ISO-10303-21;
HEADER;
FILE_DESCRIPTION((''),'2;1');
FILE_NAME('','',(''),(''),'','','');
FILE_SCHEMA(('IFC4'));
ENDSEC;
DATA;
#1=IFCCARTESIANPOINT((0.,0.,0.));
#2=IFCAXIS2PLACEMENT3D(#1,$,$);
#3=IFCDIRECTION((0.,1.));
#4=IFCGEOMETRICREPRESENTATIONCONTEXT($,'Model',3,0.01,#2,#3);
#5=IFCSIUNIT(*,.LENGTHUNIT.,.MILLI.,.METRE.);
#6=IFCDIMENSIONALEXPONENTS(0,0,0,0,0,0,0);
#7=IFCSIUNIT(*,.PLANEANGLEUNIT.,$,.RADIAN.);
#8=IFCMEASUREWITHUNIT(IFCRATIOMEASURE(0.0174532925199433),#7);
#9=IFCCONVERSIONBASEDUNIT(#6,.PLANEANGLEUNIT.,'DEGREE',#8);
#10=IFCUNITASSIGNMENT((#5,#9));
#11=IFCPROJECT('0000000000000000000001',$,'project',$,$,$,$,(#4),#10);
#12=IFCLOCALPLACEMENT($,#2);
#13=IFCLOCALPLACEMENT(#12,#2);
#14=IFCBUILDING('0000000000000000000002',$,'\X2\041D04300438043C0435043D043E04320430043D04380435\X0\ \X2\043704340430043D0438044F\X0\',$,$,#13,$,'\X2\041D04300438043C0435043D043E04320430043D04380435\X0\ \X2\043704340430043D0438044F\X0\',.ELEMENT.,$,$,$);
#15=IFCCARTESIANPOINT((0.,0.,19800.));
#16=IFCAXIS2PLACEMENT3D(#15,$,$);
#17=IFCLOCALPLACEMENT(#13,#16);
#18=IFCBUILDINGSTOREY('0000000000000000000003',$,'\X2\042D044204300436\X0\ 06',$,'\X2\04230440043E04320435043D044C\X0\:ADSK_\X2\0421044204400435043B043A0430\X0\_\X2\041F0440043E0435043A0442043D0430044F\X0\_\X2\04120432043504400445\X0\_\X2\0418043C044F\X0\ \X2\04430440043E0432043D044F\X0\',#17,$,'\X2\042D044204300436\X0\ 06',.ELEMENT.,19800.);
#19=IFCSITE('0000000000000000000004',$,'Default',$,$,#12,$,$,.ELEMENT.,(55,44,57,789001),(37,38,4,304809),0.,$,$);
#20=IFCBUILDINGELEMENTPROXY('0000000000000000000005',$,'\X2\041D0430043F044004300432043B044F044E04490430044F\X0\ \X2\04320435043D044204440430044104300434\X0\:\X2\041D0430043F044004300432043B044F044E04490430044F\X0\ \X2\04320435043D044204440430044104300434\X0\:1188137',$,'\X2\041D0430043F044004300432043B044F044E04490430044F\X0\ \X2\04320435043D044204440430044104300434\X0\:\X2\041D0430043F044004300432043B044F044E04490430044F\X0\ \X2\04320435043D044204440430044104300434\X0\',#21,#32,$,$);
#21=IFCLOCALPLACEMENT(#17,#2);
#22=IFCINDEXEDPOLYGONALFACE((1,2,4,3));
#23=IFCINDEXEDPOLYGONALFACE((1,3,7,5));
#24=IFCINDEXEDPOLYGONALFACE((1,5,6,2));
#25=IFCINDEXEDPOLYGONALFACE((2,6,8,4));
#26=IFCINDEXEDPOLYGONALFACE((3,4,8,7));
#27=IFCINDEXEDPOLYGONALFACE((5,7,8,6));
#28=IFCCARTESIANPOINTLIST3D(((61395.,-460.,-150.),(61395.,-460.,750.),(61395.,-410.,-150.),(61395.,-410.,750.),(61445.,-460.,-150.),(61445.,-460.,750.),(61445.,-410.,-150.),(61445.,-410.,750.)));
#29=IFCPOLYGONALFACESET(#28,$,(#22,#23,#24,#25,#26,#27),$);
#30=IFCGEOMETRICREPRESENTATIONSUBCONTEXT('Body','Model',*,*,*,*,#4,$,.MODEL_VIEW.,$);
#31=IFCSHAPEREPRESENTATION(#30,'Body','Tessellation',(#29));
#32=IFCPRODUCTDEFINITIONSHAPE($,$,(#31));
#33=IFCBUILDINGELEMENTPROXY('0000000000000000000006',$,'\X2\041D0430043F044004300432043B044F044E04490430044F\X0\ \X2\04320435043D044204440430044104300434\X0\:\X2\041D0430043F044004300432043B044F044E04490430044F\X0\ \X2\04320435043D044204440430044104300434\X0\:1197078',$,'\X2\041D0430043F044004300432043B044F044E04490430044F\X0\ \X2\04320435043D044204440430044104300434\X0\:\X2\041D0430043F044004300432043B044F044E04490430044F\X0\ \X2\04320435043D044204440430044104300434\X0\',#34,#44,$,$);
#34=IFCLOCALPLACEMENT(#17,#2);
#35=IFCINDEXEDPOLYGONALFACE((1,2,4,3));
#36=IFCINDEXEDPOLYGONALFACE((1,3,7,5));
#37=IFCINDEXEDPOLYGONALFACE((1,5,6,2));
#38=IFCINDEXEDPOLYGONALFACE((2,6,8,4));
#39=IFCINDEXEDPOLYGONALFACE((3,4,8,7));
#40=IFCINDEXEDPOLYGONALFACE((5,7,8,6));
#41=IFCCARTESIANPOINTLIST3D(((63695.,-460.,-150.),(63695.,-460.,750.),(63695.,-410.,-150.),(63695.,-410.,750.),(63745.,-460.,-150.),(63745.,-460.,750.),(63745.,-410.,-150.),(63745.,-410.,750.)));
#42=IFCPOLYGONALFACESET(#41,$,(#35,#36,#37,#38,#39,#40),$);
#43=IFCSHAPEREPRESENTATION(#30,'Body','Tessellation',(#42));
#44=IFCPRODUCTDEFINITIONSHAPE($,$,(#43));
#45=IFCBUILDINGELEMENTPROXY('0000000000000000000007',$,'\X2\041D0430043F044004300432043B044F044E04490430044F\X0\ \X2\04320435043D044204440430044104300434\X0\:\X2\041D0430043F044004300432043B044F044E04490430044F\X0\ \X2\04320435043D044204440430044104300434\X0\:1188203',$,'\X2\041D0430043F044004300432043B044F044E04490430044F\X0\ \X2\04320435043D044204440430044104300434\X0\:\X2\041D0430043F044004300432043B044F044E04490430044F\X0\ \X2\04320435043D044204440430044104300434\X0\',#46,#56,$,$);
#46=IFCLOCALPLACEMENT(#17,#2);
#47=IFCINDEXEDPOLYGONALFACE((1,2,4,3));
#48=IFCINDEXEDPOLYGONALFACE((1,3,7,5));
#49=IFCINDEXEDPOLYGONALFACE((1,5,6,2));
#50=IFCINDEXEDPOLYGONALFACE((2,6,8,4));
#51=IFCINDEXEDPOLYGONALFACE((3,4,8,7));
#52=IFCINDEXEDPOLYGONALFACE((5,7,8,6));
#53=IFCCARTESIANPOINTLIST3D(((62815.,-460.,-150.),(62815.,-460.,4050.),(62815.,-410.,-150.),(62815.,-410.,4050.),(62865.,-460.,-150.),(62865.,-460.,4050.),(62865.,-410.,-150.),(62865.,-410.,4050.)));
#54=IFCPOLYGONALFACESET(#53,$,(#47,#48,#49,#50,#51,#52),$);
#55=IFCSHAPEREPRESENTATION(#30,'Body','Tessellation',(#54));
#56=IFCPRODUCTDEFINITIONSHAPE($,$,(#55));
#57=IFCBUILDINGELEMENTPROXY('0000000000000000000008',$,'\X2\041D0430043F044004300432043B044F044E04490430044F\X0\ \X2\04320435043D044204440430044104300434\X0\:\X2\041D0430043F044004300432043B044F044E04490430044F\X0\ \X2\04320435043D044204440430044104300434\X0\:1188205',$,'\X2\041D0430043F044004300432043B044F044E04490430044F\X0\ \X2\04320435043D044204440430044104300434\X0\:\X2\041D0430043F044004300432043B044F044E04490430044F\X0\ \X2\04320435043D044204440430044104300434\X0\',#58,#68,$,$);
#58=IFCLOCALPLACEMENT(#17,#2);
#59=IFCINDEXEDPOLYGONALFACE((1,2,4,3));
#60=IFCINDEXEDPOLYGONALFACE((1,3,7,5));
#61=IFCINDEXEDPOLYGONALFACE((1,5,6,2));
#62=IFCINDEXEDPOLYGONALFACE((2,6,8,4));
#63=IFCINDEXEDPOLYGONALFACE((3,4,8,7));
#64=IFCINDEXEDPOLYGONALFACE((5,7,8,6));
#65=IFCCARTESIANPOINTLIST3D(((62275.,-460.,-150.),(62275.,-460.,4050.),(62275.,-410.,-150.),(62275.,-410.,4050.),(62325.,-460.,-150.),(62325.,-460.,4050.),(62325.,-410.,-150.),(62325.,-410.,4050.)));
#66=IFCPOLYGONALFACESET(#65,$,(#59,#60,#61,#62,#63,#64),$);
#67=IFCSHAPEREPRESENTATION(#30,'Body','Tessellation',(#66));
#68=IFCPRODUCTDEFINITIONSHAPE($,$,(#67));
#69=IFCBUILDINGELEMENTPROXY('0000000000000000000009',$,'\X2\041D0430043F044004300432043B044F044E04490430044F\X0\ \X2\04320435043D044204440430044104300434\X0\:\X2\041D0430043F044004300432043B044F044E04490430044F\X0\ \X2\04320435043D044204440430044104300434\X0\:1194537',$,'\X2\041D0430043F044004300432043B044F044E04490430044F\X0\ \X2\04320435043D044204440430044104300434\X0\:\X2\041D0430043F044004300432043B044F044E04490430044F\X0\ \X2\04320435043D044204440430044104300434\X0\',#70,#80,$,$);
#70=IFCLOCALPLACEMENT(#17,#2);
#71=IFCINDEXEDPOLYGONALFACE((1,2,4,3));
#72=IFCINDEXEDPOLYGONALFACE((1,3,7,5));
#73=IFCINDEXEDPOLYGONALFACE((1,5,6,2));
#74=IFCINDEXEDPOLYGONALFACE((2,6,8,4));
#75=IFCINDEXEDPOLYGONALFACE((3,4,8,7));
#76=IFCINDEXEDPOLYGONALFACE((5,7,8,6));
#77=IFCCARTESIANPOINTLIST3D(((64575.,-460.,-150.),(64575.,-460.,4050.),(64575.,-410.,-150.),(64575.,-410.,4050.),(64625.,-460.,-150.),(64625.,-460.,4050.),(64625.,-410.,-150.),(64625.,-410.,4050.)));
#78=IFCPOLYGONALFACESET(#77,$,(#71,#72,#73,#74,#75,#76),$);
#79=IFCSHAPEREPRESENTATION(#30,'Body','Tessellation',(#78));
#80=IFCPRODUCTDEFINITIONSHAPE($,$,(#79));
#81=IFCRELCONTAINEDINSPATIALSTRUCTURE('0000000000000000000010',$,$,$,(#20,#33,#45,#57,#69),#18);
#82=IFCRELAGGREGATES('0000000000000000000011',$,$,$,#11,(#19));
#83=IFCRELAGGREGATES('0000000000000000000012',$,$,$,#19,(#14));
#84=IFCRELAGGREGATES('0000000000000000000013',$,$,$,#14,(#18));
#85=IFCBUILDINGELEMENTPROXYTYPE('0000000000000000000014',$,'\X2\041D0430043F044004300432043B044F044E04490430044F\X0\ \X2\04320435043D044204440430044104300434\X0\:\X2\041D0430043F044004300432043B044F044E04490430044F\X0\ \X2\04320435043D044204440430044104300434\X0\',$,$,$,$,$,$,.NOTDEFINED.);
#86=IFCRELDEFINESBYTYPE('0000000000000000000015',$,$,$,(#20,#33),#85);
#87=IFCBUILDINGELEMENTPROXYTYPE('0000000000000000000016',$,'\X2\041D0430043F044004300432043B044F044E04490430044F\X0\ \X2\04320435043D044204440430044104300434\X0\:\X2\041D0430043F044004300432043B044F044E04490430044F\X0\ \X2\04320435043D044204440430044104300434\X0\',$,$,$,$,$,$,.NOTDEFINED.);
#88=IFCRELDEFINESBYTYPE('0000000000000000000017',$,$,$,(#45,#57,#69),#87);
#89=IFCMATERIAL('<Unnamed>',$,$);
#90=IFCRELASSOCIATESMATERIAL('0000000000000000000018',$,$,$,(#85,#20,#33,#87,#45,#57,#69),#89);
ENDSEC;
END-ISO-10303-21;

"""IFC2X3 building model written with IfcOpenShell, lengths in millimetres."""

from ifc_helpers import new_model, entity, si_unit, converted_unit, direction, frame, origin, origin_2d_with_axis, place, context, subcontext, project, spatial, rectangle, extrude, source, transform, mapped, material, type_object, type_shapes, element, save


model = new_model("IFC2X3")

# Units and contexts
model_context = context("Model", 3, precision=0.01, world=origin(), true_north=direction((0.0, 1.0)))
body_context = subcontext(model_context, "Body", "Model", "MODEL_VIEW")
ifc_project = project(units=[si_unit("LENGTHUNIT", "METRE", prefix="MILLI"), converted_unit("PLANEANGLEUNIT", "DEGREE", entity("IfcRatioMeasure", 0.0174532925199433), si_unit("PLANEANGLEUNIT", "RADIAN"), dimensions=[0, 0, 0, 0, 0, 0, 0])], contexts=[model_context])

# Site, building, storey
site_placement = place(None, origin())
site = spatial("IfcSite", under=ifc_project, at=site_placement, Name="Default", CompositionType="ELEMENT", RefLatitude=(55, 44, 57, 789001), RefLongitude=(37, 38, 4, 304809), RefElevation=0.0)
building_placement = place(site_placement, origin())
building = spatial("IfcBuilding", under=site, at=building_placement, Name="Наименование здания", LongName="Наименование здания", CompositionType="ELEMENT")
storey_placement = place(building_placement, frame((0.0, 0.0, 19800.0)))
storey = spatial("IfcBuildingStorey", under=building, at=storey_placement, Name="Этаж 06", ObjectType="Уровень:ADSK_Стрелка_Проектная_Вверх_Имя уровня", LongName="Этаж 06", CompositionType="ELEMENT", Elevation=19800.0)

# Building element proxies
ifc_material_1 = material(Name="<Unnamed>")
building_element_proxy_type_1 = type_object("IfcBuildingElementProxyType", Name="Направляющая вентфасад:Направляющая вентфасад", PredefinedType="NOTDEFINED", material=ifc_material_1)
shared_shape_1 = source(origin(), body_context, "Body", "SweptSolid", [
    extrude(rectangle(XDim=50.0, YDim=50.0, at=origin_2d_with_axis()), frame((25.0, -25.0, 0.0), z_axis=(0.0, 0.0, 1.0), x_axis=(-1.0, 0.0, 0.0)), (0.0, 0.0, 1.0), 900.0),
])
type_shapes(building_element_proxy_type_1, [shared_shape_1])
for number, where, name in (
    (1, (61395.0, -410.0, -150.0), "Направляющая вентфасад:Направляющая вентфасад:1188137"),
    (2, (63695.0, -410.0, -150.0), "Направляющая вентфасад:Направляющая вентфасад:1197078"),
):
    element("IfcBuildingElementProxy", number, at=place(storey_placement, frame(where)), inside=storey, type_object=building_element_proxy_type_1, material=ifc_material_1, Name=name, ObjectType="Направляющая вентфасад:Направляющая вентфасад", context=body_context, shape_type="MappedRepresentation", body=[
        mapped(shared_shape_1, transform((0.0, 0.0, 0.0), scale=1.0)),
    ])
building_element_proxy_type_2 = type_object("IfcBuildingElementProxyType", Name="Направляющая вентфасад:Направляющая вентфасад", PredefinedType="NOTDEFINED", material=ifc_material_1)
shared_shape_2 = source(origin(), body_context, "Body", "SweptSolid", [
    extrude(rectangle(XDim=50.0, YDim=50.0, at=origin_2d_with_axis()), frame((25.0, -25.0, 0.0), z_axis=(0.0, 0.0, 1.0), x_axis=(-1.0, 0.0, 0.0)), (0.0, 0.0, 1.0), 4200.0),
])
type_shapes(building_element_proxy_type_2, [shared_shape_2])
for number, where, name in (
    (3, (62815.0, -410.0, -150.0), "Направляющая вентфасад:Направляющая вентфасад:1188203"),
    (4, (62275.0, -410.0, -150.0), "Направляющая вентфасад:Направляющая вентфасад:1188205"),
    (5, (64575.0, -410.0, -150.0), "Направляющая вентфасад:Направляющая вентфасад:1194537"),
):
    element("IfcBuildingElementProxy", number, at=place(storey_placement, frame(where)), inside=storey, type_object=building_element_proxy_type_2, material=ifc_material_1, Name=name, ObjectType="Направляющая вентфасад:Направляющая вентфасад", context=body_context, shape_type="MappedRepresentation", body=[
        mapped(shared_shape_2, transform((0.0, 0.0, 0.0), scale=1.0)),
    ])

save(model, "model.ifc")
